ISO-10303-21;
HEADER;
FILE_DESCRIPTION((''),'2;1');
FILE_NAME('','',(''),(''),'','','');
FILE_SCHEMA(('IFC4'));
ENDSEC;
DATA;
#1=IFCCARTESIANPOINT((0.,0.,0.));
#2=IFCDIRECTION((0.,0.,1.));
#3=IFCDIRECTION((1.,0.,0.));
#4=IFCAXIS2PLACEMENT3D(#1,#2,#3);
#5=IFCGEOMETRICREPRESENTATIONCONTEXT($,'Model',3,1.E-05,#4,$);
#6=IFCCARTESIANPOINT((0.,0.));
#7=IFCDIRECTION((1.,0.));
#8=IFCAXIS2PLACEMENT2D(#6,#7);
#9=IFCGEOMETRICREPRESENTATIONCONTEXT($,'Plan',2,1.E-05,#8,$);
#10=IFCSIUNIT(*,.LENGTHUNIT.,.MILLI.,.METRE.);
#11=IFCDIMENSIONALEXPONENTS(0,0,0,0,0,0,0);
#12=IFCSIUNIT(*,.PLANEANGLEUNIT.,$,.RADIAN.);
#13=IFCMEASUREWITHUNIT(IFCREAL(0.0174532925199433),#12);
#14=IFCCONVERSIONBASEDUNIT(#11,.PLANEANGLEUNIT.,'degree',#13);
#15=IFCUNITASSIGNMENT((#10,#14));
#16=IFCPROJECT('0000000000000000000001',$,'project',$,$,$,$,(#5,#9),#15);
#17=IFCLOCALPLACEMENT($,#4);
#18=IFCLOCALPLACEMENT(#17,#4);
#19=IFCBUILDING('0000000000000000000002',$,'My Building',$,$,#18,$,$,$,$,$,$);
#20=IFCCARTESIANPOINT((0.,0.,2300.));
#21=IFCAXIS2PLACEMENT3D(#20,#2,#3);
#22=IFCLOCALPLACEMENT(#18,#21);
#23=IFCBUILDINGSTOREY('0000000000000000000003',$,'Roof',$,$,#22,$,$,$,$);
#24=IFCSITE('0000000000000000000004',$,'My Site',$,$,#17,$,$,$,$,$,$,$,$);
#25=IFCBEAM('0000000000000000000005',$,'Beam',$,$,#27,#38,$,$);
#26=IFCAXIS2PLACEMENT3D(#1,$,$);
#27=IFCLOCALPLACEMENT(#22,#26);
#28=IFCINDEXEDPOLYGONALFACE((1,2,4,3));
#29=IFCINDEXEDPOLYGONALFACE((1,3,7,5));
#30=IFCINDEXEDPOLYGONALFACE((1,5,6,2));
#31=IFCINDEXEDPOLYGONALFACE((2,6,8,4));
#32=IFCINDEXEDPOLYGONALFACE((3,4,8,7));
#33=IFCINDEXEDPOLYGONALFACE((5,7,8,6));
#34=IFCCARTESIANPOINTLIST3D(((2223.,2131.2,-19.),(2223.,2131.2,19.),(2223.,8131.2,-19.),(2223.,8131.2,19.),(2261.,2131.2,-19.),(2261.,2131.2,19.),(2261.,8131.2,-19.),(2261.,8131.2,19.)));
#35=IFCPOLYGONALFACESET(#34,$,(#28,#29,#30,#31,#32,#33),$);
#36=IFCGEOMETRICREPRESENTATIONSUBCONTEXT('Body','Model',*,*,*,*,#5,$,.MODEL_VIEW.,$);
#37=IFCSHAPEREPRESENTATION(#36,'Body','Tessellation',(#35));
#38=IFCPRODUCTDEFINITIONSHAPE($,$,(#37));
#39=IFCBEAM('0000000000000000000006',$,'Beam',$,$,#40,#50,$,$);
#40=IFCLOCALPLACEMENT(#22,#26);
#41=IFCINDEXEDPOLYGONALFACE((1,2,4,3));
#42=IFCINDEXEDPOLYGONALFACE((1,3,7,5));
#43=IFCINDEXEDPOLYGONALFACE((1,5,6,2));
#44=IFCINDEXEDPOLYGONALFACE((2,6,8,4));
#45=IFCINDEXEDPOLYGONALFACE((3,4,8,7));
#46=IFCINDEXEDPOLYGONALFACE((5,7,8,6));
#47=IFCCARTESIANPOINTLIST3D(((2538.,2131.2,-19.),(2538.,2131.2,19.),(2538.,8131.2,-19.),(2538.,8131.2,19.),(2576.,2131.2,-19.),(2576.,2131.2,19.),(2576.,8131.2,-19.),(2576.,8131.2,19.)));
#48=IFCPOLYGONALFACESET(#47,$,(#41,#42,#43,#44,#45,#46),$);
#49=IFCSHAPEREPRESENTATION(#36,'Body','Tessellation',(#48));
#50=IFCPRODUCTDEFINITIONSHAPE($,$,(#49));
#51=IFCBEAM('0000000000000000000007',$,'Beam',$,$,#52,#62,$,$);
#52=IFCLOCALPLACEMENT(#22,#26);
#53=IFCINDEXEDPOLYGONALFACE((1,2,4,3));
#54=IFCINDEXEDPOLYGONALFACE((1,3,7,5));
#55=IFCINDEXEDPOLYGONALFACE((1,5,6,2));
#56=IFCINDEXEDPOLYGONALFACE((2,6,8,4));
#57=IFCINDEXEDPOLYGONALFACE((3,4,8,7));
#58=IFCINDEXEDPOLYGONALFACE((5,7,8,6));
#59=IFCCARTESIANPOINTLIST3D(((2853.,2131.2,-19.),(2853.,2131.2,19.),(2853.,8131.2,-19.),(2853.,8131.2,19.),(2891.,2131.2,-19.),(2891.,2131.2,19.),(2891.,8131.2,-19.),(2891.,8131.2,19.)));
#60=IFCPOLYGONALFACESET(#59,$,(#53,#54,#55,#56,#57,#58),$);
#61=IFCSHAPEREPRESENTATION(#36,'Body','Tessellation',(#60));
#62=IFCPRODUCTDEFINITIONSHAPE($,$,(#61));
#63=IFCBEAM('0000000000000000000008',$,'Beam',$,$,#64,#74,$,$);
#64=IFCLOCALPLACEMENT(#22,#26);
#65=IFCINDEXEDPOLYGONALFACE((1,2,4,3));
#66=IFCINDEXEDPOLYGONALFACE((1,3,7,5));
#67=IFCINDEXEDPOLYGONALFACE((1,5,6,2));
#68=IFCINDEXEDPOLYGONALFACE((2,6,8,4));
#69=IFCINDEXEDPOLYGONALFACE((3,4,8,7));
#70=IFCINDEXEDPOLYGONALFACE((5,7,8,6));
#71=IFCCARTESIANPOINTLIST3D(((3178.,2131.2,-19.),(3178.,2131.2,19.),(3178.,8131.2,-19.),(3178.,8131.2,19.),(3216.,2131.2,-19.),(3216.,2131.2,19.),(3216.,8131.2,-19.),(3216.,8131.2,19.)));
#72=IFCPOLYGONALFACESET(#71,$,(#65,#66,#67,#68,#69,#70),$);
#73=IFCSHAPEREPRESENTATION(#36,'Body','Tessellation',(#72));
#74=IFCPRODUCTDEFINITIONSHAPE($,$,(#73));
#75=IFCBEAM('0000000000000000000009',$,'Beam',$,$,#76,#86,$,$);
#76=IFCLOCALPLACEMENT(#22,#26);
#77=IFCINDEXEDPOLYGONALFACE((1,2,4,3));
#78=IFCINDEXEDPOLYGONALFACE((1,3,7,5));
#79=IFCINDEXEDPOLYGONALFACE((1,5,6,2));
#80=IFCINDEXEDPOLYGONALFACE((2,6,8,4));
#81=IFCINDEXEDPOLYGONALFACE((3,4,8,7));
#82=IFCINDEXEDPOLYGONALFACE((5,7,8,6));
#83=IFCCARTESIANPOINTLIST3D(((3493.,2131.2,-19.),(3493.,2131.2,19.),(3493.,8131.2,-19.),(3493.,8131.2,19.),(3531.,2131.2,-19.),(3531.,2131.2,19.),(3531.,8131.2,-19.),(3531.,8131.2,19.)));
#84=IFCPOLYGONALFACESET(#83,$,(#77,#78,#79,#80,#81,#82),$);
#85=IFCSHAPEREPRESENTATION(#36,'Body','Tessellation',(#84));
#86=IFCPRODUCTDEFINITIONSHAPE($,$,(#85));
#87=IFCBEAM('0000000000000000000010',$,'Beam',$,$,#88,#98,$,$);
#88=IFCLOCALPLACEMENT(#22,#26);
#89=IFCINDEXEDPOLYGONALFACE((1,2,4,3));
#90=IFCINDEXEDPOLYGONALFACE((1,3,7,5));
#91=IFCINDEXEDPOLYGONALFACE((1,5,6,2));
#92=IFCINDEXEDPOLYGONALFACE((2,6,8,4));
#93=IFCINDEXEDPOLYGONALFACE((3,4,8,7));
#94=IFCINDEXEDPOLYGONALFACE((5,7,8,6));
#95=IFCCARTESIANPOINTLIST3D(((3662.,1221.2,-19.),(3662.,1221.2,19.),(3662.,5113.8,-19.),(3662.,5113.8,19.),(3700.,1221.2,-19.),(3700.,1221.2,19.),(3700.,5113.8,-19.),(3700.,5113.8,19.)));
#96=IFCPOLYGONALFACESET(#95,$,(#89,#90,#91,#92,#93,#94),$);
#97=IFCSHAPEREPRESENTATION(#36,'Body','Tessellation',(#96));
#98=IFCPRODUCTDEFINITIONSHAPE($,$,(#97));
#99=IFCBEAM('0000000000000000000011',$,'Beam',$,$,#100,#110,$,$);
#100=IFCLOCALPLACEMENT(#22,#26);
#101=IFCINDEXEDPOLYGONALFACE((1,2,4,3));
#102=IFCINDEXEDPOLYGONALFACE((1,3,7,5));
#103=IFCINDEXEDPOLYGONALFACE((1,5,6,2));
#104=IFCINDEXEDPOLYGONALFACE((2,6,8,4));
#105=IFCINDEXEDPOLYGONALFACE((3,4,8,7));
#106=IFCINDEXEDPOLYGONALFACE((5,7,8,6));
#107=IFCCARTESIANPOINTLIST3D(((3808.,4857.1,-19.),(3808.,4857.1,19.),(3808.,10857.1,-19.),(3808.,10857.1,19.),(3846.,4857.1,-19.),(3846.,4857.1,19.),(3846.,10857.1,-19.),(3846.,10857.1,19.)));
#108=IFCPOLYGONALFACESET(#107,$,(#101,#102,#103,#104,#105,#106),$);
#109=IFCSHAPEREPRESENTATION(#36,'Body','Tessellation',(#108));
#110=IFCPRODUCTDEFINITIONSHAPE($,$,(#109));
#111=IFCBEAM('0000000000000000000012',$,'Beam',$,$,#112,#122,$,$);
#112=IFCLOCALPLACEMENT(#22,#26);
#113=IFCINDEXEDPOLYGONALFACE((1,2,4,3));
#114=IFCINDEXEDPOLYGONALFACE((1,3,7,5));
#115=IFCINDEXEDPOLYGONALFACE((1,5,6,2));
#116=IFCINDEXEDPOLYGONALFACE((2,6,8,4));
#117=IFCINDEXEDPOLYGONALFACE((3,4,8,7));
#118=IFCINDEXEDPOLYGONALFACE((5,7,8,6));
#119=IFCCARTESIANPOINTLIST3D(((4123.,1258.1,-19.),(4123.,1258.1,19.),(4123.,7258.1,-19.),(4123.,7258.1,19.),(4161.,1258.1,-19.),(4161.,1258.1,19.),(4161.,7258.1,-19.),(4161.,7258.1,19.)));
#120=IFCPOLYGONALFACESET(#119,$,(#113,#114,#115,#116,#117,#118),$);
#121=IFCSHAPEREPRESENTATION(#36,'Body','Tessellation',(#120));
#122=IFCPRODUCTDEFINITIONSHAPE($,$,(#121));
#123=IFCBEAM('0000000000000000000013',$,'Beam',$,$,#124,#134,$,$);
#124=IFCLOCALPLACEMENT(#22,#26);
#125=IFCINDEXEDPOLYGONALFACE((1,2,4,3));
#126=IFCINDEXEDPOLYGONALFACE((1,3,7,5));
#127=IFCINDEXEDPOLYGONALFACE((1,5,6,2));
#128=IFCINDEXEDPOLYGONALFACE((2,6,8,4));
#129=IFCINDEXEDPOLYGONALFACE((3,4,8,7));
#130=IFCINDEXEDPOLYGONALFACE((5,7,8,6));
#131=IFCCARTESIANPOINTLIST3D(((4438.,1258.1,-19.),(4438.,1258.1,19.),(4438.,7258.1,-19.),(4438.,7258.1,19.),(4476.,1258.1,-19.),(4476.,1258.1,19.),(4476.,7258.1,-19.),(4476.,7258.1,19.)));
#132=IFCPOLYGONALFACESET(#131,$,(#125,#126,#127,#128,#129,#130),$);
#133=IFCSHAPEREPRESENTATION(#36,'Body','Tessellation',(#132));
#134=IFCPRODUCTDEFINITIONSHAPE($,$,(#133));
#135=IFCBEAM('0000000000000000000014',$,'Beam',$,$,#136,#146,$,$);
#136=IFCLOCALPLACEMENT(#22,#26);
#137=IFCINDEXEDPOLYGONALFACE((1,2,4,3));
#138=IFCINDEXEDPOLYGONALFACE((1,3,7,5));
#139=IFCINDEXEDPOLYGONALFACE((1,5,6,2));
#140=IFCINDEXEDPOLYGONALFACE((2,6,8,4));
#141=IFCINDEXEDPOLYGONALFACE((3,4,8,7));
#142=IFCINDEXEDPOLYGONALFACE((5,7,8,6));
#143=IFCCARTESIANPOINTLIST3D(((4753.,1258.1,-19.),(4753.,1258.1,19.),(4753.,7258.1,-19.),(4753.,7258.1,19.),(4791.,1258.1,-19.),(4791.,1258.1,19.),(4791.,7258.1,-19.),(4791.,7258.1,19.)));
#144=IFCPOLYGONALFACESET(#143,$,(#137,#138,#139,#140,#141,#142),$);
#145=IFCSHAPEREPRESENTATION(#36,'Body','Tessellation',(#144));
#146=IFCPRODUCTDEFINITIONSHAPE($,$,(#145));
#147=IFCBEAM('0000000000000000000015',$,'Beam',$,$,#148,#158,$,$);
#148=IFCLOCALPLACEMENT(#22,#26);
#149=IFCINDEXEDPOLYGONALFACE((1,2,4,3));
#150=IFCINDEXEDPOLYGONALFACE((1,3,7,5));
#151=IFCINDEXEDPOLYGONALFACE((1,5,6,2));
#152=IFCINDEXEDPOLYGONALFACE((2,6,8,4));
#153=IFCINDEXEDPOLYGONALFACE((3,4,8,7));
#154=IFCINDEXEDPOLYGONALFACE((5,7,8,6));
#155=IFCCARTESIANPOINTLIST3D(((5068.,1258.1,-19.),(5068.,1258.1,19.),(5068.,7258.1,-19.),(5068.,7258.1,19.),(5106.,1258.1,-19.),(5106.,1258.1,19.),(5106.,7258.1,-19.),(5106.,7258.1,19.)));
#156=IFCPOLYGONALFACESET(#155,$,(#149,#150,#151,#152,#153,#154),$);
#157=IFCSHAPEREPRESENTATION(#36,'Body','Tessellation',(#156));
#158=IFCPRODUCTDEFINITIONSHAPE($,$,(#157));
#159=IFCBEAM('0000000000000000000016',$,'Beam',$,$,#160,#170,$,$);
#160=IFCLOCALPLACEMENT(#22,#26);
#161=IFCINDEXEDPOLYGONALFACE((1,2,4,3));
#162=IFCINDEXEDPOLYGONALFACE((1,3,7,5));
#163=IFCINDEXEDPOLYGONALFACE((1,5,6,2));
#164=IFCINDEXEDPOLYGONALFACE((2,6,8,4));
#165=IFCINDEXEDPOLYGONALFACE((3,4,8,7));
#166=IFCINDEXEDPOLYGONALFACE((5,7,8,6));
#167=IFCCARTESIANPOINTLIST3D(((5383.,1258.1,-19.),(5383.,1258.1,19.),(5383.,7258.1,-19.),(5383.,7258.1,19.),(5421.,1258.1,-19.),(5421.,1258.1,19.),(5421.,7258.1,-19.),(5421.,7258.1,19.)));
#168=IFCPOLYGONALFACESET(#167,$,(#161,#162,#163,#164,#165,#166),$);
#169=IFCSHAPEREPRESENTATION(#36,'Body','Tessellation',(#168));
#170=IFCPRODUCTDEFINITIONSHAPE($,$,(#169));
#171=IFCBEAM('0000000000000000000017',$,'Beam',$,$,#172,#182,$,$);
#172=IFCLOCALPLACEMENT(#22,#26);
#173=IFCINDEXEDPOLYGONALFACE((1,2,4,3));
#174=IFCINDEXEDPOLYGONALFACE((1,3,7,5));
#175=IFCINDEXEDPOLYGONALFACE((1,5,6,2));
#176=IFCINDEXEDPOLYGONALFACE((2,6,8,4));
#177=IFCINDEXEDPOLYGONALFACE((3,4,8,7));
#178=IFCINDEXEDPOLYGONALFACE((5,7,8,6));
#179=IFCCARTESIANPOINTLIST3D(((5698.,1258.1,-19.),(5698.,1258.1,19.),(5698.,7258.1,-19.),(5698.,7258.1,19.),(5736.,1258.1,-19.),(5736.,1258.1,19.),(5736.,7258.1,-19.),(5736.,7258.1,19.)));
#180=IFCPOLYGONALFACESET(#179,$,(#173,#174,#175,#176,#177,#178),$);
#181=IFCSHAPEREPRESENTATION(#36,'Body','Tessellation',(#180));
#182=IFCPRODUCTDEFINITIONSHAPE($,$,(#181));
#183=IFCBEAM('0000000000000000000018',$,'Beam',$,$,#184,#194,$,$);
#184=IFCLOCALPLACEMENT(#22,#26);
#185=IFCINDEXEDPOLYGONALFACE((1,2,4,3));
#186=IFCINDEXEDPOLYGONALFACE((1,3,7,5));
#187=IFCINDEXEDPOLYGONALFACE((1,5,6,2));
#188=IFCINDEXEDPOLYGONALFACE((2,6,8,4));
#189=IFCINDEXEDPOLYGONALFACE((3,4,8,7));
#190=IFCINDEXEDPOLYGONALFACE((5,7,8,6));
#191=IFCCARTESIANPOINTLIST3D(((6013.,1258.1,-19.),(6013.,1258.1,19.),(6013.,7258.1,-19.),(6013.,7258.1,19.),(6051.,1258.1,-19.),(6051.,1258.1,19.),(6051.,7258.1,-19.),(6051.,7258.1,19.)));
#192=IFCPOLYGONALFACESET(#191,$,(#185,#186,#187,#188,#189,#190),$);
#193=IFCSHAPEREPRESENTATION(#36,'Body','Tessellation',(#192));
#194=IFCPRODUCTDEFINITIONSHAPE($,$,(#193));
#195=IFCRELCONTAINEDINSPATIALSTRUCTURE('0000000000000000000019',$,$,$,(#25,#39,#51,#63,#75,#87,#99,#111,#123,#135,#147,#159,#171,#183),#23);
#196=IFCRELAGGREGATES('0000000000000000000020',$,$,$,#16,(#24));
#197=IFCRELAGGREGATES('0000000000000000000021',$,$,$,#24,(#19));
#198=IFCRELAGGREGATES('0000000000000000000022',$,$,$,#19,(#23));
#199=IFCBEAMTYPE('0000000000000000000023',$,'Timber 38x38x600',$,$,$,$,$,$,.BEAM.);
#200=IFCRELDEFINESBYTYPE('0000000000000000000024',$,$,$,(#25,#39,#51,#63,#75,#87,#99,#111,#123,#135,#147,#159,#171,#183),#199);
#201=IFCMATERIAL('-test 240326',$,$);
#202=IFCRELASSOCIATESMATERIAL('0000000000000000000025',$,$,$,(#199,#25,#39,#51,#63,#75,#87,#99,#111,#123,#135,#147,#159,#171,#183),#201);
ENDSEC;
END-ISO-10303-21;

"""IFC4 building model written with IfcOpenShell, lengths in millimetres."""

from ifc_helpers import new_model, entity, si_unit, converted_unit, frame, origin_with_axes, origin_2d_with_axis, place, context, subcontext, project, spatial, rectangle, extrude, material, material_profile, profile_set, profile_usage, type_object, element, save


model = new_model("IFC4")

# Units and contexts
model_context = context("Model", 3, precision=1e-05, world=origin_with_axes())
plan_context = context("Plan", 2, precision=1e-05, world=origin_2d_with_axis())
body_context = subcontext(model_context, "Body", "Model", "MODEL_VIEW")
ifc_project = project(units=[si_unit("LENGTHUNIT", "METRE", prefix="MILLI"), converted_unit("PLANEANGLEUNIT", "degree", entity("IfcReal", 0.0174532925199433), si_unit("PLANEANGLEUNIT", "RADIAN"), dimensions=[0, 0, 0, 0, 0, 0, 0])], contexts=[model_context, plan_context])

# Site, building, storey
site_placement = place(None, origin_with_axes())
site = spatial("IfcSite", under=ifc_project, at=site_placement, Name="My Site")
building_placement = place(site_placement, origin_with_axes())
building = spatial("IfcBuilding", under=site, at=building_placement, Name="My Building")
storey_placement = place(building_placement, frame((0.0, 0.0, 2300.0), z_axis=(0.0, 0.0, 1.0), x_axis=(1.0, 0.0, 0.0)))
storey = spatial("IfcBuildingStorey", under=building, at=storey_placement, Name="Roof")

# Beams
ifc_material = material(Name="-test 240326")
ifc_material_profile = material_profile(ifc_material, rectangle(XDim=38.0, YDim=38.0))
ifc_profile_set = profile_set([ifc_material_profile])
beam_type_1 = type_object("IfcBeamType", Name="Timber 38x38x600", PredefinedType="BEAM", material=ifc_profile_set)
ifc_profile_usage_1 = profile_usage(ifc_profile_set, cardinal=5)
beam_1_placement = place(storey_placement, frame((2242.0, 2131.2, 0.0), z_axis=(0.0, 1.0, 0.0), x_axis=(-1.0, 0.0, 0.0)))
element("IfcBeam", 1, at=beam_1_placement, inside=storey, type_object=beam_type_1, material=ifc_profile_usage_1, Name="Beam", context=body_context, shape_type="SweptSolid", body=[
    extrude(rectangle(XDim=38.0, YDim=38.0), origin_with_axes(), (0.0, 0.0, 1.0), 6000.0),
])
ifc_profile_usage_2 = profile_usage(ifc_profile_set, cardinal=5)
beam_2_placement = place(storey_placement, frame((2557.0, 2131.2, 0.0), z_axis=(0.0, 1.0, 0.0), x_axis=(-1.0, 0.0, 0.0)))
element("IfcBeam", 2, at=beam_2_placement, inside=storey, type_object=beam_type_1, material=ifc_profile_usage_2, Name="Beam", context=body_context, shape_type="SweptSolid", body=[
    extrude(rectangle(XDim=38.0, YDim=38.0), origin_with_axes(), (0.0, 0.0, 1.0), 6000.0),
])
ifc_profile_usage_3 = profile_usage(ifc_profile_set, cardinal=5)
beam_3_placement = place(storey_placement, frame((2872.0, 2131.2, 0.0), z_axis=(0.0, 1.0, 0.0), x_axis=(-1.0, 0.0, 0.0)))
element("IfcBeam", 3, at=beam_3_placement, inside=storey, type_object=beam_type_1, material=ifc_profile_usage_3, Name="Beam", context=body_context, shape_type="SweptSolid", body=[
    extrude(rectangle(XDim=38.0, YDim=38.0), origin_with_axes(), (0.0, 0.0, 1.0), 6000.0),
])
ifc_profile_usage_4 = profile_usage(ifc_profile_set, cardinal=5)
beam_4_placement = place(storey_placement, frame((3197.0, 2131.2, 0.0), z_axis=(0.0, 1.0, 0.0), x_axis=(-1.0, 0.0, 0.0)))
element("IfcBeam", 4, at=beam_4_placement, inside=storey, type_object=beam_type_1, material=ifc_profile_usage_4, Name="Beam", context=body_context, shape_type="SweptSolid", body=[
    extrude(rectangle(XDim=38.0, YDim=38.0), origin_with_axes(), (0.0, 0.0, 1.0), 6000.0),
])
ifc_profile_usage_5 = profile_usage(ifc_profile_set, cardinal=5)
beam_5_placement = place(storey_placement, frame((3512.0, 2131.2, 0.0), z_axis=(0.0, 1.0, 0.0), x_axis=(-1.0, 0.0, 0.0)))
element("IfcBeam", 5, at=beam_5_placement, inside=storey, type_object=beam_type_1, material=ifc_profile_usage_5, Name="Beam", context=body_context, shape_type="SweptSolid", body=[
    extrude(rectangle(XDim=38.0, YDim=38.0), origin_with_axes(), (0.0, 0.0, 1.0), 6000.0),
])
ifc_profile_usage_6 = profile_usage(ifc_profile_set, cardinal=5)
beam_6_placement = place(storey_placement, frame((3681.0, 1221.2, 0.0), z_axis=(0.0, 1.0, 0.0), x_axis=(-1.0, 0.0, 0.0)))
element("IfcBeam", 6, at=beam_6_placement, inside=storey, type_object=beam_type_1, material=ifc_profile_usage_6, Name="Beam", context=body_context, shape_type="SweptSolid", body=[
    extrude(rectangle(XDim=38.0, YDim=38.0), origin_with_axes(), (0.0, 0.0, 1.0), 3892.6),
])
ifc_profile_usage_7 = profile_usage(ifc_profile_set, cardinal=5)
beam_7_placement = place(storey_placement, frame((3827.0, 4857.1, 0.0), z_axis=(0.0, 1.0, 0.0), x_axis=(-1.0, 0.0, 0.0)))
element("IfcBeam", 7, at=beam_7_placement, inside=storey, type_object=beam_type_1, material=ifc_profile_usage_7, Name="Beam", context=body_context, shape_type="SweptSolid", body=[
    extrude(rectangle(XDim=38.0, YDim=38.0), origin_with_axes(), (0.0, 0.0, 1.0), 6000.0),
])
ifc_profile_usage_8 = profile_usage(ifc_profile_set, cardinal=5)
beam_8_placement = place(storey_placement, frame((4142.0, 1258.1, 0.0), z_axis=(0.0, 1.0, 0.0), x_axis=(-1.0, 0.0, 0.0)))
element("IfcBeam", 8, at=beam_8_placement, inside=storey, type_object=beam_type_1, material=ifc_profile_usage_8, Name="Beam", context=body_context, shape_type="SweptSolid", body=[
    extrude(rectangle(XDim=38.0, YDim=38.0), origin_with_axes(), (0.0, 0.0, 1.0), 6000.0),
])
ifc_profile_usage_9 = profile_usage(ifc_profile_set, cardinal=5)
beam_9_placement = place(storey_placement, frame((4457.0, 1258.1, 0.0), z_axis=(0.0, 1.0, 0.0), x_axis=(-1.0, 0.0, 0.0)))
element("IfcBeam", 9, at=beam_9_placement, inside=storey, type_object=beam_type_1, material=ifc_profile_usage_9, Name="Beam", context=body_context, shape_type="SweptSolid", body=[
    extrude(rectangle(XDim=38.0, YDim=38.0), origin_with_axes(), (0.0, 0.0, 1.0), 6000.0),
])
ifc_profile_usage_10 = profile_usage(ifc_profile_set, cardinal=5)
beam_10_placement = place(storey_placement, frame((4772.0, 1258.1, 0.0), z_axis=(0.0, 1.0, 0.0), x_axis=(-1.0, 0.0, 0.0)))
element("IfcBeam", 10, at=beam_10_placement, inside=storey, type_object=beam_type_1, material=ifc_profile_usage_10, Name="Beam", context=body_context, shape_type="SweptSolid", body=[
    extrude(rectangle(XDim=38.0, YDim=38.0), origin_with_axes(), (0.0, 0.0, 1.0), 6000.0),
])
ifc_profile_usage_11 = profile_usage(ifc_profile_set, cardinal=5)
beam_11_placement = place(storey_placement, frame((5087.0, 1258.1, 0.0), z_axis=(0.0, 1.0, 0.0), x_axis=(-1.0, 0.0, 0.0)))
element("IfcBeam", 11, at=beam_11_placement, inside=storey, type_object=beam_type_1, material=ifc_profile_usage_11, Name="Beam", context=body_context, shape_type="SweptSolid", body=[
    extrude(rectangle(XDim=38.0, YDim=38.0), origin_with_axes(), (0.0, 0.0, 1.0), 6000.0),
])
ifc_profile_usage_12 = profile_usage(ifc_profile_set, cardinal=5)
beam_12_placement = place(storey_placement, frame((5402.0, 1258.1, 0.0), z_axis=(0.0, 1.0, 0.0), x_axis=(-1.0, 0.0, 0.0)))
element("IfcBeam", 12, at=beam_12_placement, inside=storey, type_object=beam_type_1, material=ifc_profile_usage_12, Name="Beam", context=body_context, shape_type="SweptSolid", body=[
    extrude(rectangle(XDim=38.0, YDim=38.0), origin_with_axes(), (0.0, 0.0, 1.0), 6000.0),
])
ifc_profile_usage_13 = profile_usage(ifc_profile_set, cardinal=5)
beam_13_placement = place(storey_placement, frame((5717.0, 1258.1, 0.0), z_axis=(0.0, 1.0, 0.0), x_axis=(-1.0, 0.0, 0.0)))
element("IfcBeam", 13, at=beam_13_placement, inside=storey, type_object=beam_type_1, material=ifc_profile_usage_13, Name="Beam", context=body_context, shape_type="SweptSolid", body=[
    extrude(rectangle(XDim=38.0, YDim=38.0), origin_with_axes(), (0.0, 0.0, 1.0), 6000.0),
])
ifc_profile_usage_14 = profile_usage(ifc_profile_set, cardinal=5)
beam_14_placement = place(storey_placement, frame((6032.0, 1258.1, 0.0), z_axis=(0.0, 1.0, 0.0), x_axis=(-1.0, 0.0, 0.0)))
element("IfcBeam", 14, at=beam_14_placement, inside=storey, type_object=beam_type_1, material=ifc_profile_usage_14, Name="Beam", context=body_context, shape_type="SweptSolid", body=[
    extrude(rectangle(XDim=38.0, YDim=38.0), origin_with_axes(), (0.0, 0.0, 1.0), 6000.0),
])

save(model, "model.ifc")
